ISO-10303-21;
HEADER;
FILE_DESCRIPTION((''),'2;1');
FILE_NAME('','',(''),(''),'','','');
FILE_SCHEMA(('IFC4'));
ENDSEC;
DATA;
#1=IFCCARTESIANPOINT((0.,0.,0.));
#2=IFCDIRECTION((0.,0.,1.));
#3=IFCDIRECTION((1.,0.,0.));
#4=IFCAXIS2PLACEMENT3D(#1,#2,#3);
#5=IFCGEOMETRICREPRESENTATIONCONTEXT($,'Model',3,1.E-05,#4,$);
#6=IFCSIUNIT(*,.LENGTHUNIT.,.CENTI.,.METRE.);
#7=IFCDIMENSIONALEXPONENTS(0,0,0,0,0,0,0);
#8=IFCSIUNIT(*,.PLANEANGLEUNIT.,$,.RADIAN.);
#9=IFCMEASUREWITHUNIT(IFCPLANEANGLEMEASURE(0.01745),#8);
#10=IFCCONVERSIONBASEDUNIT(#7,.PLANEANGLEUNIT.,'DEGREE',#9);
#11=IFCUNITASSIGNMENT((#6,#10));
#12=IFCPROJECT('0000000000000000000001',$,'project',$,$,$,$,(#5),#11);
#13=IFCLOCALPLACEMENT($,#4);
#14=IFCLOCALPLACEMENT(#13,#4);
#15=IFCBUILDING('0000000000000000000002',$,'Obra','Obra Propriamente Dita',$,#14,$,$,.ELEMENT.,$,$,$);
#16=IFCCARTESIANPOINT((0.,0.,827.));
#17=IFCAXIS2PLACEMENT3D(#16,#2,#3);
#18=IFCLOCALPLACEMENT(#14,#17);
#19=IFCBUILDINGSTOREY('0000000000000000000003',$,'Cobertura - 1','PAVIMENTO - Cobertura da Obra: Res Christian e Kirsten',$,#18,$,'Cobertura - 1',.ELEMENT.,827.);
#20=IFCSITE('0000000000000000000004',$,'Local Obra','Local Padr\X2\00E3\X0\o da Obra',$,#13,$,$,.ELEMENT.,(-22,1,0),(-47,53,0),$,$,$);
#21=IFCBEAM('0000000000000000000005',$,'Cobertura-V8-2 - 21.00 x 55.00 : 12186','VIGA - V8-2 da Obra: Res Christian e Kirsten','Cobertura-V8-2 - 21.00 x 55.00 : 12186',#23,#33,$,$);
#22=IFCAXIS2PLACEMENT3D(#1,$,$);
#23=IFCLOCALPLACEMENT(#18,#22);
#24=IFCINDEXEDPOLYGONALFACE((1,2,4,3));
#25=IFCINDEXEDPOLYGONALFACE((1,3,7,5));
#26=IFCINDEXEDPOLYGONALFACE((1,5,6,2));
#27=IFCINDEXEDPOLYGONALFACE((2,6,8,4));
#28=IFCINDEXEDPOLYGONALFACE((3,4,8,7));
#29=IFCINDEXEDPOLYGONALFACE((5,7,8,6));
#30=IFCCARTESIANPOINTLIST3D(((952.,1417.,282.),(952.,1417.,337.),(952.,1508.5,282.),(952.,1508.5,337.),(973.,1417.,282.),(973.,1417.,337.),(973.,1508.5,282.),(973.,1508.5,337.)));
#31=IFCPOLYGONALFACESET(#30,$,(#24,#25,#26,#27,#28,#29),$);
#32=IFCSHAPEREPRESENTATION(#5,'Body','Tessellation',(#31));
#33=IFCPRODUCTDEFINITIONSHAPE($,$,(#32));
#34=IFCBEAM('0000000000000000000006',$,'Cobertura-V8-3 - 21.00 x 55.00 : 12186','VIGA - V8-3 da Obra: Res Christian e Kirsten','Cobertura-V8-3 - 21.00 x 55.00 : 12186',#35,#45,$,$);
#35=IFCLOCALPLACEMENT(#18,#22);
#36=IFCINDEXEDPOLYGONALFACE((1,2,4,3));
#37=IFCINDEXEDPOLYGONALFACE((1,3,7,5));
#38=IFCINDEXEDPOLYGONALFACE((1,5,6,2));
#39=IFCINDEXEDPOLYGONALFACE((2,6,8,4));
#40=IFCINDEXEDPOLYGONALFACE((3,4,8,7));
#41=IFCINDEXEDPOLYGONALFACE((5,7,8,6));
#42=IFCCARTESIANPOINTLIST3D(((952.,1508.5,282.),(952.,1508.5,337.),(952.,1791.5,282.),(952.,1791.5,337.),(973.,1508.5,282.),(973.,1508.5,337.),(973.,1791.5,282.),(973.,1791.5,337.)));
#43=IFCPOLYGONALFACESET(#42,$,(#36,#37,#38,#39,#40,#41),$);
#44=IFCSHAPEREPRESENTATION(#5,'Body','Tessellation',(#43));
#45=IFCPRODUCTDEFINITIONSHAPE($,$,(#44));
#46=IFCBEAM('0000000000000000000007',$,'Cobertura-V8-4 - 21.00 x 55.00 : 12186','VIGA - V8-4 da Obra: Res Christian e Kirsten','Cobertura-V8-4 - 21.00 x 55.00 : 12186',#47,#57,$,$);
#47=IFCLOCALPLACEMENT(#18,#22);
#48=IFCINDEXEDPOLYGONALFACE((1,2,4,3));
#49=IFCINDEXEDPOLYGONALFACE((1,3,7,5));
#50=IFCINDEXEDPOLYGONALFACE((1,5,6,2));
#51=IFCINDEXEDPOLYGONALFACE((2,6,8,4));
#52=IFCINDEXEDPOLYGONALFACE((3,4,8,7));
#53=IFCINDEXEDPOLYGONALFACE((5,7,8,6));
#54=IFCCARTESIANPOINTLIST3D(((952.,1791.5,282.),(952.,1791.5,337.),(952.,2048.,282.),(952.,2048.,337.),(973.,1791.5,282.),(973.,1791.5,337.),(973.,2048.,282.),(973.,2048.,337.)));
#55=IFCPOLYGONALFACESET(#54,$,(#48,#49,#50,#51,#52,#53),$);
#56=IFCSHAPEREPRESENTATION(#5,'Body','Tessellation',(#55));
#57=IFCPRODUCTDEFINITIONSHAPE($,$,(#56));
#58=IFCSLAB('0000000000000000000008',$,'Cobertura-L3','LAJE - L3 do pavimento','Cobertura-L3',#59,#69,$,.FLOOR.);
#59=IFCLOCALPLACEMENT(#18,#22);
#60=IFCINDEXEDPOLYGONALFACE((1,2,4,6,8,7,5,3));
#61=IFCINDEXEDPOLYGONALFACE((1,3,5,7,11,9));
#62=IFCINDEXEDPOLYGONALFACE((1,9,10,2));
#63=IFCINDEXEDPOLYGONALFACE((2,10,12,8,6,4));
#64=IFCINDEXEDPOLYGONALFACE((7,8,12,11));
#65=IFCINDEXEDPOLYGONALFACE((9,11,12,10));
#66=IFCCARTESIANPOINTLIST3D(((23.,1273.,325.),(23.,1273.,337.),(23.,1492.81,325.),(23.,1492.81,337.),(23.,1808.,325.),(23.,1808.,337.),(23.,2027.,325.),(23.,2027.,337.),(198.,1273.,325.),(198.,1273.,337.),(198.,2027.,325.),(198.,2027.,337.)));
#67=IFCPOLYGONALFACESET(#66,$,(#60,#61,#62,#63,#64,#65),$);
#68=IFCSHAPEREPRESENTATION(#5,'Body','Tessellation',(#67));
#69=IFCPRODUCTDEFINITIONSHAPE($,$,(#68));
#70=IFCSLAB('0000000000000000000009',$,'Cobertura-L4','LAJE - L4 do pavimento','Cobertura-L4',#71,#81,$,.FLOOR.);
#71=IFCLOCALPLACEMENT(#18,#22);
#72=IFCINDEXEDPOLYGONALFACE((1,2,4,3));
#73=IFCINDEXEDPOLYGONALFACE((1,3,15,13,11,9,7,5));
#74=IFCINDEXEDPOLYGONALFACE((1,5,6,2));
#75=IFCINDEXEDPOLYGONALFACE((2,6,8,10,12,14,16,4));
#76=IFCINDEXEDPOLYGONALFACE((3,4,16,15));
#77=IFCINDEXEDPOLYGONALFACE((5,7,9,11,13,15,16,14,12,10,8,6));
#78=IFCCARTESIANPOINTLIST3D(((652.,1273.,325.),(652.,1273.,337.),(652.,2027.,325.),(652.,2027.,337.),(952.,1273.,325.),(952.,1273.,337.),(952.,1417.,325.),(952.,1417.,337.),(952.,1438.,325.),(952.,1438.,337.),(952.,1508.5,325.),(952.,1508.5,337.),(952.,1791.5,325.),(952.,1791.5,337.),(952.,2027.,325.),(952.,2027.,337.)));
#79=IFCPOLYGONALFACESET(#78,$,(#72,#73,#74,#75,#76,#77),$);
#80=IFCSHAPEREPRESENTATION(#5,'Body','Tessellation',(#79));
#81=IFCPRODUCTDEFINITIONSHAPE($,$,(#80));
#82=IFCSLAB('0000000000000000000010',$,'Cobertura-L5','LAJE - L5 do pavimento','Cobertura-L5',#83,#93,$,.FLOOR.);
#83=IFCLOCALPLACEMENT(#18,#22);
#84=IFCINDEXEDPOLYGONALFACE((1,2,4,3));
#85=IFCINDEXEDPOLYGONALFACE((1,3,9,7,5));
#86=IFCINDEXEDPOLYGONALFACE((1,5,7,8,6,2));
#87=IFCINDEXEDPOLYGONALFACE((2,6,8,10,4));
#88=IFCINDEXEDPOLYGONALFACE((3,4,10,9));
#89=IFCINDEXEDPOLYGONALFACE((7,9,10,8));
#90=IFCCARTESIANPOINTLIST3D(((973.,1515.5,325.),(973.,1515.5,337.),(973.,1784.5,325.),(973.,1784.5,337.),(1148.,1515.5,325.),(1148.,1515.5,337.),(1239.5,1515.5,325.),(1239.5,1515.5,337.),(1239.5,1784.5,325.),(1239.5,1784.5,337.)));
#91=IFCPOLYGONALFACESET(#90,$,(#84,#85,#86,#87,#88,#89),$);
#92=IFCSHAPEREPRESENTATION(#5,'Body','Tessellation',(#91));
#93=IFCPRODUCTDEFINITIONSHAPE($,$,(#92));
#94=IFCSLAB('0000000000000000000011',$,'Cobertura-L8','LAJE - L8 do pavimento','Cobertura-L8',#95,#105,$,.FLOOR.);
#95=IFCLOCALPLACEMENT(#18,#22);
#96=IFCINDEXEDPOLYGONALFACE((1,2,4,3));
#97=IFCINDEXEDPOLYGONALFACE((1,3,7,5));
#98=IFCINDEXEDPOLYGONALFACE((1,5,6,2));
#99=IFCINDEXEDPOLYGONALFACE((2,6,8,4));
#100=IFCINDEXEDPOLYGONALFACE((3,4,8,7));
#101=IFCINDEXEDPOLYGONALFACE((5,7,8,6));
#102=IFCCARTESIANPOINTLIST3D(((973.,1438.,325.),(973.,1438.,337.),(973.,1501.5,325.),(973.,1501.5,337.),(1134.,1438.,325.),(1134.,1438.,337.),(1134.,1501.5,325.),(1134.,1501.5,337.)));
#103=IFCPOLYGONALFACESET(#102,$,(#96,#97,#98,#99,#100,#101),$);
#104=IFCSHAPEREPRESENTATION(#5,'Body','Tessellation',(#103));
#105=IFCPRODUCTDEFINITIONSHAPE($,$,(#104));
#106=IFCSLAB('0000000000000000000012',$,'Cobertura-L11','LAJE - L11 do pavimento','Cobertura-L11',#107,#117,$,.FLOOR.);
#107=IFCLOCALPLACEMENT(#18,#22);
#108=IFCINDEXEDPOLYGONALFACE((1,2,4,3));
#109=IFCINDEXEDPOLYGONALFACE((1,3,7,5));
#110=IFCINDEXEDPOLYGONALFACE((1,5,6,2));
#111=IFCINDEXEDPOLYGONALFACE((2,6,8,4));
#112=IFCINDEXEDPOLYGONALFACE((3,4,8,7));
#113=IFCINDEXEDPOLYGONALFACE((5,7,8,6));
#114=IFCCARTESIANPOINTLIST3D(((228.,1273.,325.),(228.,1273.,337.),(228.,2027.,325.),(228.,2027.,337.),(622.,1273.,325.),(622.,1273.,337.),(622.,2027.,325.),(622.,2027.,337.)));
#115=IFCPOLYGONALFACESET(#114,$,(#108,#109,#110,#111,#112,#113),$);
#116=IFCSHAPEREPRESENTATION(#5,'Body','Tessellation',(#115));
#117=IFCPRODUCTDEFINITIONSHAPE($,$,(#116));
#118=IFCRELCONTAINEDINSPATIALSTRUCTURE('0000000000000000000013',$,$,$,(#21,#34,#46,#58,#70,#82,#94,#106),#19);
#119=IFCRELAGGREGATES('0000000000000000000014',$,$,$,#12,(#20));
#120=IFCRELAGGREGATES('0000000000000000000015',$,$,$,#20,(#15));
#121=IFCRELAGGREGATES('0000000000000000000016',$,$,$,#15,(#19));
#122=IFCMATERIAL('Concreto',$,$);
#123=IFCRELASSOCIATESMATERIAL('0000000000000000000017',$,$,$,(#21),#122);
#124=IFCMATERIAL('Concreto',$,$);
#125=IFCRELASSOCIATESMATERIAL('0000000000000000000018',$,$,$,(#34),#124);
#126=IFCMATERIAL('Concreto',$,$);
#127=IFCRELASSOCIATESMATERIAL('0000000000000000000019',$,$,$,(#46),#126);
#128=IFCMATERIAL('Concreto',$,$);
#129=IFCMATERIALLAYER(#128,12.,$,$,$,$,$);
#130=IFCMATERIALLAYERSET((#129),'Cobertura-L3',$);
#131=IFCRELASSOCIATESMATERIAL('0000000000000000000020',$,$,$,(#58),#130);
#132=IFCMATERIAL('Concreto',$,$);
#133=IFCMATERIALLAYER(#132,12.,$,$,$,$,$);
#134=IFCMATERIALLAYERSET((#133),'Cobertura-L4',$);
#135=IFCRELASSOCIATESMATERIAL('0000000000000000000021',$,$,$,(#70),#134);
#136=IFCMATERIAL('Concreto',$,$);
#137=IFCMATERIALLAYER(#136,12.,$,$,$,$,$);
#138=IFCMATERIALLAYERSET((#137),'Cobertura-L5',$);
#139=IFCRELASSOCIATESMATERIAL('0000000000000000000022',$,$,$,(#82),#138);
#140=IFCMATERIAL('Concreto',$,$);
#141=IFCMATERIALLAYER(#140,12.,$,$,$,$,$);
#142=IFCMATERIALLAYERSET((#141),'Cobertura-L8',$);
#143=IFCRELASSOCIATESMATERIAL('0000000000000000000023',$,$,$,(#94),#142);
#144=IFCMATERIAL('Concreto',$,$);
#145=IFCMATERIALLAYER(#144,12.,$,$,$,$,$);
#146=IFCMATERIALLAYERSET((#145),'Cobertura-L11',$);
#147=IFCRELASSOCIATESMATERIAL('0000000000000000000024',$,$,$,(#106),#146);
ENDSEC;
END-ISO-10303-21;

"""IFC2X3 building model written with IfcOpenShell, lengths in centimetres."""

from ifc_helpers import new_model, entity, si_unit, converted_unit, frame, origin_with_axes, place, context, project, spatial, polyline, outline, extrude, material, layer, layer_set, layer_usage, element, save


model = new_model("IFC2X3")

# Units and contexts
model_context = context("Model", 3, precision=1e-05, world=origin_with_axes())
ifc_project = project(units=[si_unit("LENGTHUNIT", "METRE", prefix="CENTI"), converted_unit("PLANEANGLEUNIT", "DEGREE", entity("IfcPlaneAngleMeasure", 0.01745), si_unit("PLANEANGLEUNIT", "RADIAN"), dimensions=[0, 0, 0, 0, 0, 0, 0])], contexts=[model_context])

# Site, building, storey
site_placement = place(None, origin_with_axes())
site = spatial("IfcSite", under=ifc_project, at=site_placement, Name="Local Obra", Description="Local Padrão da Obra", CompositionType="ELEMENT", RefLatitude=(-22, 1, 0), RefLongitude=(-47, 53, 0))
building_placement = place(site_placement, origin_with_axes())
building = spatial("IfcBuilding", under=site, at=building_placement, Name="Obra", Description="Obra Propriamente Dita", CompositionType="ELEMENT")
storey_placement = place(building_placement, frame((0.0, 0.0, 827.0), z_axis=(0.0, 0.0, 1.0), x_axis=(1.0, 0.0, 0.0)))
storey = spatial("IfcBuildingStorey", under=building, at=storey_placement, Name="Cobertura - 1", Description="PAVIMENTO - Cobertura da Obra: Res Christian e Kirsten", LongName="Cobertura - 1", CompositionType="ELEMENT", Elevation=827.0)

# Beams
ifc_material_1 = material(Name="Concreto")
beam_1_placement = place(storey_placement, frame((952.0, 1417.0, 337.0), z_axis=(0.0, 1.0, 0.0), x_axis=(1.0, 0.0, 0.0)))
element("IfcBeam", 1, at=beam_1_placement, inside=storey, material=ifc_material_1, Name="Cobertura-V8-2 - 21.00 x 55.00 : 12186", Description="VIGA - V8-2 da Obra: Res Christian e Kirsten", ObjectType="Cobertura-V8-2 - 21.00 x 55.00 : 12186", context=model_context, shape_type="SweptSolid", body=[
    extrude(outline(polyline([(0.0, 0.0), (21.0, 0.0), (21.0, 55.0), (0.0, 55.0), (0.0, 0.0)])), origin_with_axes(), (0.0, 0.0, 1.0), 91.5),
])
ifc_material_2 = material(Name="Concreto")
beam_2_placement = place(storey_placement, frame((952.0, 1508.5, 337.0), z_axis=(-0.000001, 1.0, 0.0), x_axis=(1.0, 0.000001, 0.0)))
element("IfcBeam", 2, at=beam_2_placement, inside=storey, material=ifc_material_2, Name="Cobertura-V8-3 - 21.00 x 55.00 : 12186", Description="VIGA - V8-3 da Obra: Res Christian e Kirsten", ObjectType="Cobertura-V8-3 - 21.00 x 55.00 : 12186", context=model_context, shape_type="SweptSolid", body=[
    extrude(outline(polyline([(0.0, 0.0), (21.0, 0.0), (21.0, 55.0), (0.0, 55.0), (0.0, 0.0)])), origin_with_axes(), (0.0, 0.0, 1.0), 283.0),
])
ifc_material_3 = material(Name="Concreto")
beam_3_placement = place(storey_placement, frame((952.0, 1791.5, 337.0), z_axis=(0.0, 1.0, 0.0), x_axis=(1.0, 0.0, 0.0)))
element("IfcBeam", 3, at=beam_3_placement, inside=storey, material=ifc_material_3, Name="Cobertura-V8-4 - 21.00 x 55.00 : 12186", Description="VIGA - V8-4 da Obra: Res Christian e Kirsten", ObjectType="Cobertura-V8-4 - 21.00 x 55.00 : 12186", context=model_context, shape_type="SweptSolid", body=[
    extrude(outline(polyline([(0.0, 0.0), (21.0, 0.0), (21.0, 55.0), (0.0, 55.0), (0.0, 0.0)])), origin_with_axes(), (0.0, 0.0, 1.0), 256.5),
])

# Slabs
ifc_material_4 = material(Name="Concreto")
ifc_layer_1 = layer(ifc_material_4, 12.0)
ifc_layer_set_1 = layer_set([ifc_layer_1], Name="Cobertura-L3")
ifc_layer_usage_1 = layer_usage(ifc_layer_set_1, "AXIS3", "POSITIVE", 0.0)
slab_1_placement = place(storey_placement, frame((23.0, 2027.0, 325.0), z_axis=(0.0, 0.0, 1.0), x_axis=(1.0, 0.0, 0.0)))
element("IfcSlab", 4, at=slab_1_placement, inside=storey, material=ifc_layer_usage_1, Name="Cobertura-L3", Description="LAJE - L3 do pavimento", ObjectType="Cobertura-L3", PredefinedType="FLOOR", context=model_context, shape_type="SweptSolid", body=[
    extrude(outline(polyline([(0.0, -219.0), (0.0, -534.19), (0.0, -754.0), (175.0, -754.0), (175.0, 0.0), (0.0, 0.0), (0.0, -219.0)])), origin_with_axes(), (0.0, 0.0, 1.0), 12.0),
])
ifc_material_5 = material(Name="Concreto")
ifc_layer_2 = layer(ifc_material_5, 12.0)
ifc_layer_set_2 = layer_set([ifc_layer_2], Name="Cobertura-L4")
ifc_layer_usage_2 = layer_usage(ifc_layer_set_2, "AXIS3", "POSITIVE", 0.0)
slab_2_placement = place(storey_placement, frame((952.0, 1791.5, 325.0), z_axis=(0.0, 0.0, 1.0), x_axis=(1.0, 0.0, 0.0)))
element("IfcSlab", 5, at=slab_2_placement, inside=storey, material=ifc_layer_usage_2, Name="Cobertura-L4", Description="LAJE - L4 do pavimento", ObjectType="Cobertura-L4", PredefinedType="FLOOR", context=model_context, shape_type="SweptSolid", body=[
    extrude(outline(polyline([(0.0, 235.5), (-300.0, 235.5), (-300.0, -518.5), (0.0, -518.5), (0.0, -374.5), (0.0, -353.5), (0.0, -283.0), (0.0, 0.0), (0.0, 235.5)])), origin_with_axes(), (0.0, 0.0, 1.0), 12.0),
])
ifc_material_6 = material(Name="Concreto")
ifc_layer_3 = layer(ifc_material_6, 12.0)
ifc_layer_set_3 = layer_set([ifc_layer_3], Name="Cobertura-L5")
ifc_layer_usage_3 = layer_usage(ifc_layer_set_3, "AXIS3", "POSITIVE", 0.0)
slab_3_placement = place(storey_placement, frame((973.0, 1515.5, 325.0), z_axis=(0.0, 0.0, 1.0), x_axis=(1.0, 0.0, 0.0)))
element("IfcSlab", 6, at=slab_3_placement, inside=storey, material=ifc_layer_usage_3, Name="Cobertura-L5", Description="LAJE - L5 do pavimento", ObjectType="Cobertura-L5", PredefinedType="FLOOR", context=model_context, shape_type="SweptSolid", body=[
    extrude(outline(polyline([(175.0, 0.0), (266.5, 0.0), (266.5, 269.0), (0.0, 269.0), (0.0, 0.0), (175.0, 0.0)])), origin_with_axes(), (0.0, 0.0, 1.0), 12.0),
])
ifc_material_7 = material(Name="Concreto")
ifc_layer_4 = layer(ifc_material_7, 12.0)
ifc_layer_set_4 = layer_set([ifc_layer_4], Name="Cobertura-L8")
ifc_layer_usage_4 = layer_usage(ifc_layer_set_4, "AXIS3", "POSITIVE", 0.0)
slab_4_placement = place(storey_placement, frame((1134.0, 1438.0, 325.0), z_axis=(0.0, 0.0, 1.0), x_axis=(1.0, 0.0, 0.0)))
element("IfcSlab", 7, at=slab_4_placement, inside=storey, material=ifc_layer_usage_4, Name="Cobertura-L8", Description="LAJE - L8 do pavimento", ObjectType="Cobertura-L8", PredefinedType="FLOOR", context=model_context, shape_type="SweptSolid", body=[
    extrude(outline(polyline([(0.0, 63.5), (-161.0, 63.5), (-161.0, 0.0), (0.0, 0.0), (0.0, 63.5)])), origin_with_axes(), (0.0, 0.0, 1.0), 12.0),
])
ifc_material_8 = material(Name="Concreto")
ifc_layer_5 = layer(ifc_material_8, 12.0)
ifc_layer_set_5 = layer_set([ifc_layer_5], Name="Cobertura-L11")
ifc_layer_usage_5 = layer_usage(ifc_layer_set_5, "AXIS3", "POSITIVE", 0.0)
slab_5_placement = place(storey_placement, frame((622.0, 1273.0, 325.0), z_axis=(0.0, 0.0, 1.0), x_axis=(1.0, 0.0, 0.0)))
element("IfcSlab", 8, at=slab_5_placement, inside=storey, material=ifc_layer_usage_5, Name="Cobertura-L11", Description="LAJE - L11 do pavimento", ObjectType="Cobertura-L11", PredefinedType="FLOOR", context=model_context, shape_type="SweptSolid", body=[
    extrude(outline(polyline([(0.0, 754.0), (-394.0, 754.0), (-394.0, 0.0), (0.0, 0.0), (0.0, 754.0)])), origin_with_axes(), (0.0, 0.0, 1.0), 12.0),
])

save(model, "model.ifc")
